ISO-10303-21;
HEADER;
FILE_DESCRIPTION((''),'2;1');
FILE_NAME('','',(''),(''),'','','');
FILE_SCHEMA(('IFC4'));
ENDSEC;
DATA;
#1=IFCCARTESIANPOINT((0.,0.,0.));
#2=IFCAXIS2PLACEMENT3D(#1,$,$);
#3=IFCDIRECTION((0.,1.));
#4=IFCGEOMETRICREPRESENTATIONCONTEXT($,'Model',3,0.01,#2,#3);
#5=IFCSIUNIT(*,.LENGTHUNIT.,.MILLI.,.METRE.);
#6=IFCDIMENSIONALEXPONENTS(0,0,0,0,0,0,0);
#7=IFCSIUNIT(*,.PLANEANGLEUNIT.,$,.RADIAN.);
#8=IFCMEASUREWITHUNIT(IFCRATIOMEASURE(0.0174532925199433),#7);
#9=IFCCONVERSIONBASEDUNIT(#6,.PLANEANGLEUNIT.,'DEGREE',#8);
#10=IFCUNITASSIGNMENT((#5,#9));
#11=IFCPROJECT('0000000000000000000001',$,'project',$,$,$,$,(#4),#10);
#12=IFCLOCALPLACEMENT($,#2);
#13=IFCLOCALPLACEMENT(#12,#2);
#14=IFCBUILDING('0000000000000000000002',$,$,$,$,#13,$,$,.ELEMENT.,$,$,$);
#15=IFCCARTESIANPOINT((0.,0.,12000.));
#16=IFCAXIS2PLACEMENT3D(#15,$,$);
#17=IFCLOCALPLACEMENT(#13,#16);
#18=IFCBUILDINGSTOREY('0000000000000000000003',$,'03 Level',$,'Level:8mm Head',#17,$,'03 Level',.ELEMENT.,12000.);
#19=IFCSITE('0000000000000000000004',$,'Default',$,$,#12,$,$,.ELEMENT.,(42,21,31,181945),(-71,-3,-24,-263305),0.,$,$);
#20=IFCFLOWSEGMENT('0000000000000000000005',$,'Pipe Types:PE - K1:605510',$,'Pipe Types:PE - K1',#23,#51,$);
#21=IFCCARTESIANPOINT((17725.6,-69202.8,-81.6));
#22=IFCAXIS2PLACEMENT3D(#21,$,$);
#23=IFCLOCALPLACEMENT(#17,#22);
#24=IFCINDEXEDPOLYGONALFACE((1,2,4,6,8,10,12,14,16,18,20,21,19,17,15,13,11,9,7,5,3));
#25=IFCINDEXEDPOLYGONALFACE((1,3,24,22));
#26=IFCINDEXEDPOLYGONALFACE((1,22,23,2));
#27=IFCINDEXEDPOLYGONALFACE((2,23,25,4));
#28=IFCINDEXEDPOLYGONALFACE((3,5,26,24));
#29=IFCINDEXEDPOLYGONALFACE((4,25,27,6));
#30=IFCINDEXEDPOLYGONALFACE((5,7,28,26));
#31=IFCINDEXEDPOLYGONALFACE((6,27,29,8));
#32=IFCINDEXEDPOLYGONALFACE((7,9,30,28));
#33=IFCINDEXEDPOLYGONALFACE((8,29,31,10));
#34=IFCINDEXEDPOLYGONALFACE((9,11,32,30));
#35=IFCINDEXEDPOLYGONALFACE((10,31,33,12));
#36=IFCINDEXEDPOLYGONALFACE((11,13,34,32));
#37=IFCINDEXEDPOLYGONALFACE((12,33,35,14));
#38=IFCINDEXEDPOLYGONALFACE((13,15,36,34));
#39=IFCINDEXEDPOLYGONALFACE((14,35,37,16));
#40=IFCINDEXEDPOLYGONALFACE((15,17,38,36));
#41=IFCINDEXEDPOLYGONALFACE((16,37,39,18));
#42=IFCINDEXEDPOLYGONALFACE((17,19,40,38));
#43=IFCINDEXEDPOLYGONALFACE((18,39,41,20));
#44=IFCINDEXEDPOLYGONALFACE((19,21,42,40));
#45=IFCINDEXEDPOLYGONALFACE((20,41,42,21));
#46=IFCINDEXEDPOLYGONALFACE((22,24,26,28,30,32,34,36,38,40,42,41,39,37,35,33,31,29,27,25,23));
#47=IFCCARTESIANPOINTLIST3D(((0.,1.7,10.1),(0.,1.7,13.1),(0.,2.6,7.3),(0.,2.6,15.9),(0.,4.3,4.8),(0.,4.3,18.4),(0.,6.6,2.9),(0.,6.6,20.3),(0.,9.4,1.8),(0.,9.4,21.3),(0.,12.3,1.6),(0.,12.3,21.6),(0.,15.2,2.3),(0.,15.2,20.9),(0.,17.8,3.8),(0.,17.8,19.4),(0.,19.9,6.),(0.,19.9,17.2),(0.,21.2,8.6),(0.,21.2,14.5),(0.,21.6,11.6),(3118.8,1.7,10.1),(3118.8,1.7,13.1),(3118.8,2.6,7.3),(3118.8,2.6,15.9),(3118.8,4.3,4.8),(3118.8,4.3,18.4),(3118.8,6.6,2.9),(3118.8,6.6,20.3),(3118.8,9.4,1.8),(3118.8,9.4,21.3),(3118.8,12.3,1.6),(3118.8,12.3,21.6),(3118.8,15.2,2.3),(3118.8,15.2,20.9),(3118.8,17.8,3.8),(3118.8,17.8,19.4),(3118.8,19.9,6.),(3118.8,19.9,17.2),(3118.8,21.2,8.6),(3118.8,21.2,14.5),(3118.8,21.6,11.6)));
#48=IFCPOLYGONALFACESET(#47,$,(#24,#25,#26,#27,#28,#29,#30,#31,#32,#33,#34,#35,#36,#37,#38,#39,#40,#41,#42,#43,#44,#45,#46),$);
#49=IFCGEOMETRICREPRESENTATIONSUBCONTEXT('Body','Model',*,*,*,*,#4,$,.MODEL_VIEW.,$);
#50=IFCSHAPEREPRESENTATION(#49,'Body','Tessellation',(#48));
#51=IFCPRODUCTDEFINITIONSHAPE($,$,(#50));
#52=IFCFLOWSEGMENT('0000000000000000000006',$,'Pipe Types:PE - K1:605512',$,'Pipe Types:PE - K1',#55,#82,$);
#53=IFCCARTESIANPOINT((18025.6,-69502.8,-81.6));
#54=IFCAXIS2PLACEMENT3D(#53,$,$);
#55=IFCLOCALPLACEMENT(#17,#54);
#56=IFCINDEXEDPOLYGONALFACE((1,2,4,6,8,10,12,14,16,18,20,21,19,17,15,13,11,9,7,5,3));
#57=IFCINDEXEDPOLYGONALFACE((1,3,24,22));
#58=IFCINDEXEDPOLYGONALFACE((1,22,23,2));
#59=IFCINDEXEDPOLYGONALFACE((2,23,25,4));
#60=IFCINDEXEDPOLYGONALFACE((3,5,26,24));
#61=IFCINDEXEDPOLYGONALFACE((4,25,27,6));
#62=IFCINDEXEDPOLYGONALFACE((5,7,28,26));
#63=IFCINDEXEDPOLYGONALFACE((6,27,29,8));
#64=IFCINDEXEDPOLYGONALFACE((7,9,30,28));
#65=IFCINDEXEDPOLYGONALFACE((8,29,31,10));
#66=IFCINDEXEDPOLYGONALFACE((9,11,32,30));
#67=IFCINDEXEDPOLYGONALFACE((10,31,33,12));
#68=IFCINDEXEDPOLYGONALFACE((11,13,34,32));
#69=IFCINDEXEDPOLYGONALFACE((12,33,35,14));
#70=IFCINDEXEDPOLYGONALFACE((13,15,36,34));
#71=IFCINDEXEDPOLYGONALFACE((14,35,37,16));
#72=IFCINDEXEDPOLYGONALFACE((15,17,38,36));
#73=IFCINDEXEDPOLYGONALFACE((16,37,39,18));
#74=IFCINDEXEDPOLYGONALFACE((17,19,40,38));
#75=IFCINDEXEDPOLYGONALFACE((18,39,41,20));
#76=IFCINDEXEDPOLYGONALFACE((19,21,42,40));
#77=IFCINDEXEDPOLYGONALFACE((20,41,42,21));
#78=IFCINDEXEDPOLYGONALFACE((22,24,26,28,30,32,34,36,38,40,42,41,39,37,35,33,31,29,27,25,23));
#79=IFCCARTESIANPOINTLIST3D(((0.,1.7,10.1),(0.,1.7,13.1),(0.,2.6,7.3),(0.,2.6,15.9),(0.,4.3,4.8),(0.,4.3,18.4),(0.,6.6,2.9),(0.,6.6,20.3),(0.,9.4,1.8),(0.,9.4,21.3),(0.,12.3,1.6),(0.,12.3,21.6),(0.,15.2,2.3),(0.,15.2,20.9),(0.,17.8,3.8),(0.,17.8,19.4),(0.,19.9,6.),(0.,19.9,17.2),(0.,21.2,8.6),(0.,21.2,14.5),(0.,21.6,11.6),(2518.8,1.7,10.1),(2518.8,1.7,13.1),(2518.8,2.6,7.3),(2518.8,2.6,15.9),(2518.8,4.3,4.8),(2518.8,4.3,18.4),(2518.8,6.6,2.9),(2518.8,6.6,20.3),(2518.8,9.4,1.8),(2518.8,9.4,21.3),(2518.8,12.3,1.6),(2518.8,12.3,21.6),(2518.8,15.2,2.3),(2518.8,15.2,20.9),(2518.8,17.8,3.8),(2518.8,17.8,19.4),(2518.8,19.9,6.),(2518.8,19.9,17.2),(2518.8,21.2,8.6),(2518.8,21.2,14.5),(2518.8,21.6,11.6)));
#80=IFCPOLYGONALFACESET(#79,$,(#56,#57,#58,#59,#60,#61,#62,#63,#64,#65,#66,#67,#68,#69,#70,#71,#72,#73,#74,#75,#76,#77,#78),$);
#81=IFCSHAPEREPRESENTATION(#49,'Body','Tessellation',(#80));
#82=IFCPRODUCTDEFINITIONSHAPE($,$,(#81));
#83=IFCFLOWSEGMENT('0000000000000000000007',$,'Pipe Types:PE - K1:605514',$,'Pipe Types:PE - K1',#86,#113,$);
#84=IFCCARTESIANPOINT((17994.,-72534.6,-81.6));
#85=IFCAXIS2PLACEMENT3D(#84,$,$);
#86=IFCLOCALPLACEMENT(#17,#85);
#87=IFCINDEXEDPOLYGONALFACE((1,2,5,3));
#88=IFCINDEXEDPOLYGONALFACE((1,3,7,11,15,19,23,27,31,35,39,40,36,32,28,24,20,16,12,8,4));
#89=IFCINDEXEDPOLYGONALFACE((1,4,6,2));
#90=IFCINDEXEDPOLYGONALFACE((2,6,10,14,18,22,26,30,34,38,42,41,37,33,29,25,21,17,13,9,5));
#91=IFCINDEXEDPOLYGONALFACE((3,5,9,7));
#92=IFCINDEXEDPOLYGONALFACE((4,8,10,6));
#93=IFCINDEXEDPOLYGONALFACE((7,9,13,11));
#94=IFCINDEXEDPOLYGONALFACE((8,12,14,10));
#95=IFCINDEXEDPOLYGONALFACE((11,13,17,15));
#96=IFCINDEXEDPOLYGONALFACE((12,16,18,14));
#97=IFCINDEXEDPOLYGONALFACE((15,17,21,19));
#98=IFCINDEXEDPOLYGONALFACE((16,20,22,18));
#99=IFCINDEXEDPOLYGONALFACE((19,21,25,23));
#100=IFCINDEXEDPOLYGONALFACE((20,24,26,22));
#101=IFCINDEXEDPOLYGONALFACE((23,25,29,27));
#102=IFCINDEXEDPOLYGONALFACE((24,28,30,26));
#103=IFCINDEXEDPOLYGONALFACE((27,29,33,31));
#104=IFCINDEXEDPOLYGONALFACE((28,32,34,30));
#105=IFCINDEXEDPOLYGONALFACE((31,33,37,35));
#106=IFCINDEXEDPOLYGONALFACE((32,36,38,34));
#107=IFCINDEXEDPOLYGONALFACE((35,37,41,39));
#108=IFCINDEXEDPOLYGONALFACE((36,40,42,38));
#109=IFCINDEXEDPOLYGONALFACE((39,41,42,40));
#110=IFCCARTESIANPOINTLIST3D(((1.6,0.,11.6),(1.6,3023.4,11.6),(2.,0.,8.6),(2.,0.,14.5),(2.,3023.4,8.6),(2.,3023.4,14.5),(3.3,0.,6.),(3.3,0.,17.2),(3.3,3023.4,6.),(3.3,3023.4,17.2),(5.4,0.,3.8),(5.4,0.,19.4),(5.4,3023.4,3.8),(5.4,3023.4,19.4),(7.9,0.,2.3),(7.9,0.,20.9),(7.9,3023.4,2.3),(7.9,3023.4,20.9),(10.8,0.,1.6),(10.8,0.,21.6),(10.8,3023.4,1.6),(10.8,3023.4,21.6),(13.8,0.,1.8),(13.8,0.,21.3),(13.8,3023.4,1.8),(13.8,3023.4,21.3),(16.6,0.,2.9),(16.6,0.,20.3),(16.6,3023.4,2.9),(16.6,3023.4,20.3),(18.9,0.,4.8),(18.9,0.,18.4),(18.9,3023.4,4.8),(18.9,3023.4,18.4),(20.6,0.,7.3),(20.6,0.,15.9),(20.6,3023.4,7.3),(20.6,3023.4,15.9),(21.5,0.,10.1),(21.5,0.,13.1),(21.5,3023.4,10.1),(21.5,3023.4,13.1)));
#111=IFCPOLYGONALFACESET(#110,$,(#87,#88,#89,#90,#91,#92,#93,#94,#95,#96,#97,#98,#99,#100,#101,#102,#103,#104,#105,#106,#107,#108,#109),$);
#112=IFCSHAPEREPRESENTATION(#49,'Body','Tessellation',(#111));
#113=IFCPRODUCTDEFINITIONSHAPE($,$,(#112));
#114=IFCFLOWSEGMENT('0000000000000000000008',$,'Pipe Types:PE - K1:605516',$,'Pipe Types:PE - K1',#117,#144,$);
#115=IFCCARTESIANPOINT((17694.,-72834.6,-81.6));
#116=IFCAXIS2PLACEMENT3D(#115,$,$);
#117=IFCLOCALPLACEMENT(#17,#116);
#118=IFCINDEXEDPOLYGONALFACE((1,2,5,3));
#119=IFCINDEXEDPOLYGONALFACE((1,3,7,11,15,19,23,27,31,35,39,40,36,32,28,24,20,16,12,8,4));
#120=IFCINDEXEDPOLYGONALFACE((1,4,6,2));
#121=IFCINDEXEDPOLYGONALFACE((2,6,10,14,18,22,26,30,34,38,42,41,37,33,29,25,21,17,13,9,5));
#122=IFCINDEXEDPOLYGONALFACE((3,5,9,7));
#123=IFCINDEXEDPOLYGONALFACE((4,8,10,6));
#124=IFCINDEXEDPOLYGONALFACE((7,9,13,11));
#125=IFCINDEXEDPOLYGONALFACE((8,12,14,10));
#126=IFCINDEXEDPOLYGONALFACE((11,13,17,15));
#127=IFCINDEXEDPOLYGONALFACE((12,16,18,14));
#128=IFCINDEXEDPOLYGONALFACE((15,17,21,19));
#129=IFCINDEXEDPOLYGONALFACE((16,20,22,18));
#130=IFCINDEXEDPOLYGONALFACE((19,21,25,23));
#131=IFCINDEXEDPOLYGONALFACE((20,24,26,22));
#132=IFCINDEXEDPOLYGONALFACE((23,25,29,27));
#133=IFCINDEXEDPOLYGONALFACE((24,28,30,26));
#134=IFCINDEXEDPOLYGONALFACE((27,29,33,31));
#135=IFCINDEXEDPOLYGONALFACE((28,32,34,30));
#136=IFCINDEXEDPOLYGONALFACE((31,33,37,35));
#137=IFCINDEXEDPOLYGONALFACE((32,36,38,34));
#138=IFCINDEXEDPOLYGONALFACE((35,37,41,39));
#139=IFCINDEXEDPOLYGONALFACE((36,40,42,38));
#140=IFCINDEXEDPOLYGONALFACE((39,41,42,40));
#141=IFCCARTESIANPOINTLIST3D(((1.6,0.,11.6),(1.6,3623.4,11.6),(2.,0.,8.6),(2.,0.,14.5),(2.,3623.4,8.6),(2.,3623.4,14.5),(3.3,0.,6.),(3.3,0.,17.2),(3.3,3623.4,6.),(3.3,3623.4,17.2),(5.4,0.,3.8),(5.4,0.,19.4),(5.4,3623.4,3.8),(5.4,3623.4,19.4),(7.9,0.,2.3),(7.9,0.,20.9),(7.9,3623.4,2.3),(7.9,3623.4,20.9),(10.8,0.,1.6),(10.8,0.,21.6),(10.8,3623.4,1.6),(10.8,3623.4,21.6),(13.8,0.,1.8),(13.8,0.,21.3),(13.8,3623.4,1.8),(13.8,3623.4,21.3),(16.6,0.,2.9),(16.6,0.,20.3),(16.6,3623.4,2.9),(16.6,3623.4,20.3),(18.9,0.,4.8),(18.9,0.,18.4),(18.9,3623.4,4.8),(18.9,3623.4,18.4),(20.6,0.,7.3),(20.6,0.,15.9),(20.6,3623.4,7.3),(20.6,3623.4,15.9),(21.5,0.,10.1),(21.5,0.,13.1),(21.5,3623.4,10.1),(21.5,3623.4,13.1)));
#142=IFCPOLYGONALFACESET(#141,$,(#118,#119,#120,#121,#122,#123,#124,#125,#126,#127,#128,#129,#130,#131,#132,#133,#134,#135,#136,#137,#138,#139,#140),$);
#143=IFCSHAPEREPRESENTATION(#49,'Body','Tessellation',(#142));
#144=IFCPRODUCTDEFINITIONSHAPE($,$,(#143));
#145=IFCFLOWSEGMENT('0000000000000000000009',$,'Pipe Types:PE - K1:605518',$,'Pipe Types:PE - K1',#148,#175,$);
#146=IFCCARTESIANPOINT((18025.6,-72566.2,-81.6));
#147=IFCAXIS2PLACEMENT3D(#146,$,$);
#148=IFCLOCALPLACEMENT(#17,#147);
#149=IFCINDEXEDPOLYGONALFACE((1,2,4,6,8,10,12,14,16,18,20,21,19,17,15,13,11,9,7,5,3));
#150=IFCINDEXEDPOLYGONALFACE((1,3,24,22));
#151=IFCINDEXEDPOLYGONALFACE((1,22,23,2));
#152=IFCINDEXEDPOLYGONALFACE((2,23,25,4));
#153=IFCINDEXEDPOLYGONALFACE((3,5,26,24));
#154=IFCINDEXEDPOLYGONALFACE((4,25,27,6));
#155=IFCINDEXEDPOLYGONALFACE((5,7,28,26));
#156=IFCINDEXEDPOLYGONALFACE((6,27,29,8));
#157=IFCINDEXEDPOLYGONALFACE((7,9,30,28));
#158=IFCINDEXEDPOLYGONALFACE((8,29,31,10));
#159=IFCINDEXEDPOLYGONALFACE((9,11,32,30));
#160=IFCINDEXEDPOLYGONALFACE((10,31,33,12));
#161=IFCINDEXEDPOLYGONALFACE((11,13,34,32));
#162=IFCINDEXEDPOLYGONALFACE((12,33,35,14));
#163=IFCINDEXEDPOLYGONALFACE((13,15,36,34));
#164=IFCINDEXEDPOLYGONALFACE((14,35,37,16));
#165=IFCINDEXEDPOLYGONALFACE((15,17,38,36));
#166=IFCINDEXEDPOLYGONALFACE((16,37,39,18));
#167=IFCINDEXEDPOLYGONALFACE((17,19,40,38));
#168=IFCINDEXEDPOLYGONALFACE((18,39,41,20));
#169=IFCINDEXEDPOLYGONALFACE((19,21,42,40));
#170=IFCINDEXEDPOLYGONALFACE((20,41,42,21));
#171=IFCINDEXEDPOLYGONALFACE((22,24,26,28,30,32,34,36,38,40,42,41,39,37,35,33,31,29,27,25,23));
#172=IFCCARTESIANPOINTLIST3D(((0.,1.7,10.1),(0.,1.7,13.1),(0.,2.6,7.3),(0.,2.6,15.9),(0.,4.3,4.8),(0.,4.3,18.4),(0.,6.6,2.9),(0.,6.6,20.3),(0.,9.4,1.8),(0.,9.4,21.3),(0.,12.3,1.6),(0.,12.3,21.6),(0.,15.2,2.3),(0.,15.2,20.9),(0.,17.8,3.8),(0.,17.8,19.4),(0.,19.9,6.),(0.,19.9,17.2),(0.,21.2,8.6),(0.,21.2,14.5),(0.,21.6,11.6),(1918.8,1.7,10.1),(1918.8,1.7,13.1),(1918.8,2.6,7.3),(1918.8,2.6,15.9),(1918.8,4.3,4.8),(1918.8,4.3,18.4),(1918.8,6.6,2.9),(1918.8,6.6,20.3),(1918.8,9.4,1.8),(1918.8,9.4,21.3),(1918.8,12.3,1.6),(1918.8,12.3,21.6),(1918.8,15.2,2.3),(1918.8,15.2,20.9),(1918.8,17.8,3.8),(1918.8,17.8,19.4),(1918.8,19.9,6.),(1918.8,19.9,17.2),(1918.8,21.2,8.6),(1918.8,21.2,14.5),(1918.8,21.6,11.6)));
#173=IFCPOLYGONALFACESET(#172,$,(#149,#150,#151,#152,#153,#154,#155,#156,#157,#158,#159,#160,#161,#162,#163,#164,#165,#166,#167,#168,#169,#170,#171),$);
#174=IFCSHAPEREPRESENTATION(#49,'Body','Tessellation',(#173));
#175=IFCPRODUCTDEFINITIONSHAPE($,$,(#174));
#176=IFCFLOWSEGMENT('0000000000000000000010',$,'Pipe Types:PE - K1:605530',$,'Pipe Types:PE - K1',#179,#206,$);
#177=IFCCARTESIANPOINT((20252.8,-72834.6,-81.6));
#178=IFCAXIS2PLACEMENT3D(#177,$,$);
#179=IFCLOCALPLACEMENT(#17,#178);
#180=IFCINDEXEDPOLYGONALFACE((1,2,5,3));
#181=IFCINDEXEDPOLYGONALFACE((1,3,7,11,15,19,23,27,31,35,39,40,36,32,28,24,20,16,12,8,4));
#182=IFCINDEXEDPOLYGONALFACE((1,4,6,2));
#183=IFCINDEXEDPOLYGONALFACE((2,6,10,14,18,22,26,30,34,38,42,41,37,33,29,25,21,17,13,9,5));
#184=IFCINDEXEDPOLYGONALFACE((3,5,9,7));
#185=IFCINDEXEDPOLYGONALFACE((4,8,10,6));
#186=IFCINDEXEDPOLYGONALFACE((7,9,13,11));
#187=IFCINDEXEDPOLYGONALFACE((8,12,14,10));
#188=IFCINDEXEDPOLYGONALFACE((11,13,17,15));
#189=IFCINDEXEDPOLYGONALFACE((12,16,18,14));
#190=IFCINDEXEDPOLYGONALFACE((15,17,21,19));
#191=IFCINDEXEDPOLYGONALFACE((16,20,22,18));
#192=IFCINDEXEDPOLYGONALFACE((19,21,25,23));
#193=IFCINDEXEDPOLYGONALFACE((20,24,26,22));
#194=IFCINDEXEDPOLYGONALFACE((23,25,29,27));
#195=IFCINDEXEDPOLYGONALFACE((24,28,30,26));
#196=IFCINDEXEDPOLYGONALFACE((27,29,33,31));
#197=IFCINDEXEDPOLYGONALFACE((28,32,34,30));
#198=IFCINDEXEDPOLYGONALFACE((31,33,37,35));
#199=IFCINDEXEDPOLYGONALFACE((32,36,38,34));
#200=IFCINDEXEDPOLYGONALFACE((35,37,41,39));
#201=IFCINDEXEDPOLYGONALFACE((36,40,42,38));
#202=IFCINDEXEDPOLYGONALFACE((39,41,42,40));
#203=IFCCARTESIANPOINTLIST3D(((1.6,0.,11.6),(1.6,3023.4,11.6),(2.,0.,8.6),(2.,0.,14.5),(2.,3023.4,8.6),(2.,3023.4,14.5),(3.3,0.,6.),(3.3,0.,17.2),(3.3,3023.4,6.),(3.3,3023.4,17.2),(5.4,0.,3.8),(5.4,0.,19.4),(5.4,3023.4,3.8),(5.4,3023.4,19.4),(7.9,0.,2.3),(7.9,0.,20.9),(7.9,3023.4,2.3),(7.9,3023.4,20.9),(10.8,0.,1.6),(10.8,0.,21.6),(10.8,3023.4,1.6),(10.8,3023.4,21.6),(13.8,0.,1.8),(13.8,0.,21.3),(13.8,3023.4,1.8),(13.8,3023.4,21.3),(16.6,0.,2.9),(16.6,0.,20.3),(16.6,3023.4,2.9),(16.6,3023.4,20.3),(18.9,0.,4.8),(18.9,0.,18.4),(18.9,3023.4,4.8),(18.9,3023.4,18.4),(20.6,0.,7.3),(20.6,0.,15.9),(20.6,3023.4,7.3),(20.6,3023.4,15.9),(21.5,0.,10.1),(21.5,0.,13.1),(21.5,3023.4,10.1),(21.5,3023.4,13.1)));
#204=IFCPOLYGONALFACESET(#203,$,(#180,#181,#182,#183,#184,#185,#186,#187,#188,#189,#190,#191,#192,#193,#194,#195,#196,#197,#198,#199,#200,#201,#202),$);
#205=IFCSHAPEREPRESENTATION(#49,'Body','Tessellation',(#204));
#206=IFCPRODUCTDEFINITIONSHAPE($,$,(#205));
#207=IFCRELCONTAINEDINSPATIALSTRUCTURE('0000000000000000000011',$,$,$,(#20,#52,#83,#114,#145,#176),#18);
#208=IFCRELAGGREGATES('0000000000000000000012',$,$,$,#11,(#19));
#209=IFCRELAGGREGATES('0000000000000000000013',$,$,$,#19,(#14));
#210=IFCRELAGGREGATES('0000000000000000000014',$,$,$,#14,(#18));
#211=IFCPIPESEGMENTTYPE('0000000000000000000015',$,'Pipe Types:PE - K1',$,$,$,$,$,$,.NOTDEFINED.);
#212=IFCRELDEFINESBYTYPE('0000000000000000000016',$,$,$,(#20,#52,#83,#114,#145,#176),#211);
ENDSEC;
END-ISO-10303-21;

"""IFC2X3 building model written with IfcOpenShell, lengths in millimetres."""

from ifc_helpers import new_model, entity, si_unit, converted_unit, direction, frame, frame_2d, origin, place, context, subcontext, project, spatial, circle, extrude, type_object, element, save


model = new_model("IFC2X3")

# Units and contexts
model_context = context("Model", 3, precision=0.01, world=origin(), true_north=direction((0.0, 1.0)))
body_context = subcontext(model_context, "Body", "Model", "MODEL_VIEW")
ifc_project = project(units=[si_unit("LENGTHUNIT", "METRE", prefix="MILLI"), converted_unit("PLANEANGLEUNIT", "DEGREE", entity("IfcRatioMeasure", 0.0174532925199433), si_unit("PLANEANGLEUNIT", "RADIAN"), dimensions=[0, 0, 0, 0, 0, 0, 0])], contexts=[model_context])

# Site, building, storey
site_placement = place(None, origin())
site = spatial("IfcSite", under=ifc_project, at=site_placement, Name="Default", CompositionType="ELEMENT", RefLatitude=(42, 21, 31, 181945), RefLongitude=(-71, -3, -24, -263305), RefElevation=0.0)
building_placement = place(site_placement, origin())
building = spatial("IfcBuilding", under=site, at=building_placement, CompositionType="ELEMENT")
storey_placement = place(building_placement, frame((0.0, 0.0, 12000.0)))
storey = spatial("IfcBuildingStorey", under=building, at=storey_placement, Name="03 Level", ObjectType="Level:8mm Head", LongName="03 Level", CompositionType="ELEMENT", Elevation=12000.0)

# Flow segments
pipe_segment_type = type_object("IfcPipeSegmentType", Name="Pipe Types:PE - K1", PredefinedType="NOTDEFINED")
flow_segment_1_placement = place(storey_placement, frame((17725.6, -69202.8, -81.6)))
element("IfcFlowSegment", 1, at=flow_segment_1_placement, inside=storey, type_object=pipe_segment_type, Name="Pipe Types:PE - K1:605510", ObjectType="Pipe Types:PE - K1", context=body_context, shape_type="SweptSolid", body=[
    extrude(circle(Radius=10.0, at=frame_2d((0.0, 0.0), x_axis=(1.0, 0.0))), frame((0.0, 11.6, 11.6), z_axis=(1.0, 0.0, 0.0), x_axis=(0.0, 1.0, 0.0)), (0.0, 0.0, 1.0), 3118.8),
])
flow_segment_2_placement = place(storey_placement, frame((18025.6, -69502.8, -81.6)))
element("IfcFlowSegment", 2, at=flow_segment_2_placement, inside=storey, type_object=pipe_segment_type, Name="Pipe Types:PE - K1:605512", ObjectType="Pipe Types:PE - K1", context=body_context, shape_type="SweptSolid", body=[
    extrude(circle(Radius=10.0, at=frame_2d((0.0, 0.0), x_axis=(1.0, 0.0))), frame((0.0, 11.6, 11.6), z_axis=(1.0, 0.0, 0.0), x_axis=(0.0, 1.0, 0.0)), (0.0, 0.0, 1.0), 2518.8),
])
flow_segment_3_placement = place(storey_placement, frame((17994.0, -72534.6, -81.6)))
element("IfcFlowSegment", 3, at=flow_segment_3_placement, inside=storey, type_object=pipe_segment_type, Name="Pipe Types:PE - K1:605514", ObjectType="Pipe Types:PE - K1", context=body_context, shape_type="SweptSolid", body=[
    extrude(circle(Radius=10.0, at=frame_2d((0.0, 0.0), x_axis=(1.0, 0.0))), frame((11.6, 0.0, 11.6), z_axis=(0.0, 1.0, 0.0), x_axis=(-1.0, 0.0, 0.0)), (0.0, 0.0, 1.0), 3023.4),
])
flow_segment_4_placement = place(storey_placement, frame((17694.0, -72834.6, -81.6)))
element("IfcFlowSegment", 4, at=flow_segment_4_placement, inside=storey, type_object=pipe_segment_type, Name="Pipe Types:PE - K1:605516", ObjectType="Pipe Types:PE - K1", context=body_context, shape_type="SweptSolid", body=[
    extrude(circle(Radius=10.0, at=frame_2d((0.0, 0.0), x_axis=(1.0, 0.0))), frame((11.6, 0.0, 11.6), z_axis=(0.0, 1.0, 0.0), x_axis=(-1.0, 0.0, 0.0)), (0.0, 0.0, 1.0), 3623.4),
])
flow_segment_5_placement = place(storey_placement, frame((18025.6, -72566.2, -81.6)))
element("IfcFlowSegment", 5, at=flow_segment_5_placement, inside=storey, type_object=pipe_segment_type, Name="Pipe Types:PE - K1:605518", ObjectType="Pipe Types:PE - K1", context=body_context, shape_type="SweptSolid", body=[
    extrude(circle(Radius=10.0, at=frame_2d((0.0, 0.0), x_axis=(1.0, 0.0))), frame((0.0, 11.6, 11.6), z_axis=(1.0, 0.0, 0.0), x_axis=(0.0, 1.0, 0.0)), (0.0, 0.0, 1.0), 1918.8),
])
flow_segment_6_placement = place(storey_placement, frame((20252.8, -72834.6, -81.6)))
element("IfcFlowSegment", 6, at=flow_segment_6_placement, inside=storey, type_object=pipe_segment_type, Name="Pipe Types:PE - K1:605530", ObjectType="Pipe Types:PE - K1", context=body_context, shape_type="SweptSolid", body=[
    extrude(circle(Radius=10.0, at=frame_2d((0.0, 0.0), x_axis=(1.0, 0.0))), frame((11.6, 0.0, 11.6), z_axis=(0.0, 1.0, 0.0), x_axis=(-1.0, 0.0, 0.0)), (0.0, 0.0, 1.0), 3023.4),
])

save(model, "model.ifc")
